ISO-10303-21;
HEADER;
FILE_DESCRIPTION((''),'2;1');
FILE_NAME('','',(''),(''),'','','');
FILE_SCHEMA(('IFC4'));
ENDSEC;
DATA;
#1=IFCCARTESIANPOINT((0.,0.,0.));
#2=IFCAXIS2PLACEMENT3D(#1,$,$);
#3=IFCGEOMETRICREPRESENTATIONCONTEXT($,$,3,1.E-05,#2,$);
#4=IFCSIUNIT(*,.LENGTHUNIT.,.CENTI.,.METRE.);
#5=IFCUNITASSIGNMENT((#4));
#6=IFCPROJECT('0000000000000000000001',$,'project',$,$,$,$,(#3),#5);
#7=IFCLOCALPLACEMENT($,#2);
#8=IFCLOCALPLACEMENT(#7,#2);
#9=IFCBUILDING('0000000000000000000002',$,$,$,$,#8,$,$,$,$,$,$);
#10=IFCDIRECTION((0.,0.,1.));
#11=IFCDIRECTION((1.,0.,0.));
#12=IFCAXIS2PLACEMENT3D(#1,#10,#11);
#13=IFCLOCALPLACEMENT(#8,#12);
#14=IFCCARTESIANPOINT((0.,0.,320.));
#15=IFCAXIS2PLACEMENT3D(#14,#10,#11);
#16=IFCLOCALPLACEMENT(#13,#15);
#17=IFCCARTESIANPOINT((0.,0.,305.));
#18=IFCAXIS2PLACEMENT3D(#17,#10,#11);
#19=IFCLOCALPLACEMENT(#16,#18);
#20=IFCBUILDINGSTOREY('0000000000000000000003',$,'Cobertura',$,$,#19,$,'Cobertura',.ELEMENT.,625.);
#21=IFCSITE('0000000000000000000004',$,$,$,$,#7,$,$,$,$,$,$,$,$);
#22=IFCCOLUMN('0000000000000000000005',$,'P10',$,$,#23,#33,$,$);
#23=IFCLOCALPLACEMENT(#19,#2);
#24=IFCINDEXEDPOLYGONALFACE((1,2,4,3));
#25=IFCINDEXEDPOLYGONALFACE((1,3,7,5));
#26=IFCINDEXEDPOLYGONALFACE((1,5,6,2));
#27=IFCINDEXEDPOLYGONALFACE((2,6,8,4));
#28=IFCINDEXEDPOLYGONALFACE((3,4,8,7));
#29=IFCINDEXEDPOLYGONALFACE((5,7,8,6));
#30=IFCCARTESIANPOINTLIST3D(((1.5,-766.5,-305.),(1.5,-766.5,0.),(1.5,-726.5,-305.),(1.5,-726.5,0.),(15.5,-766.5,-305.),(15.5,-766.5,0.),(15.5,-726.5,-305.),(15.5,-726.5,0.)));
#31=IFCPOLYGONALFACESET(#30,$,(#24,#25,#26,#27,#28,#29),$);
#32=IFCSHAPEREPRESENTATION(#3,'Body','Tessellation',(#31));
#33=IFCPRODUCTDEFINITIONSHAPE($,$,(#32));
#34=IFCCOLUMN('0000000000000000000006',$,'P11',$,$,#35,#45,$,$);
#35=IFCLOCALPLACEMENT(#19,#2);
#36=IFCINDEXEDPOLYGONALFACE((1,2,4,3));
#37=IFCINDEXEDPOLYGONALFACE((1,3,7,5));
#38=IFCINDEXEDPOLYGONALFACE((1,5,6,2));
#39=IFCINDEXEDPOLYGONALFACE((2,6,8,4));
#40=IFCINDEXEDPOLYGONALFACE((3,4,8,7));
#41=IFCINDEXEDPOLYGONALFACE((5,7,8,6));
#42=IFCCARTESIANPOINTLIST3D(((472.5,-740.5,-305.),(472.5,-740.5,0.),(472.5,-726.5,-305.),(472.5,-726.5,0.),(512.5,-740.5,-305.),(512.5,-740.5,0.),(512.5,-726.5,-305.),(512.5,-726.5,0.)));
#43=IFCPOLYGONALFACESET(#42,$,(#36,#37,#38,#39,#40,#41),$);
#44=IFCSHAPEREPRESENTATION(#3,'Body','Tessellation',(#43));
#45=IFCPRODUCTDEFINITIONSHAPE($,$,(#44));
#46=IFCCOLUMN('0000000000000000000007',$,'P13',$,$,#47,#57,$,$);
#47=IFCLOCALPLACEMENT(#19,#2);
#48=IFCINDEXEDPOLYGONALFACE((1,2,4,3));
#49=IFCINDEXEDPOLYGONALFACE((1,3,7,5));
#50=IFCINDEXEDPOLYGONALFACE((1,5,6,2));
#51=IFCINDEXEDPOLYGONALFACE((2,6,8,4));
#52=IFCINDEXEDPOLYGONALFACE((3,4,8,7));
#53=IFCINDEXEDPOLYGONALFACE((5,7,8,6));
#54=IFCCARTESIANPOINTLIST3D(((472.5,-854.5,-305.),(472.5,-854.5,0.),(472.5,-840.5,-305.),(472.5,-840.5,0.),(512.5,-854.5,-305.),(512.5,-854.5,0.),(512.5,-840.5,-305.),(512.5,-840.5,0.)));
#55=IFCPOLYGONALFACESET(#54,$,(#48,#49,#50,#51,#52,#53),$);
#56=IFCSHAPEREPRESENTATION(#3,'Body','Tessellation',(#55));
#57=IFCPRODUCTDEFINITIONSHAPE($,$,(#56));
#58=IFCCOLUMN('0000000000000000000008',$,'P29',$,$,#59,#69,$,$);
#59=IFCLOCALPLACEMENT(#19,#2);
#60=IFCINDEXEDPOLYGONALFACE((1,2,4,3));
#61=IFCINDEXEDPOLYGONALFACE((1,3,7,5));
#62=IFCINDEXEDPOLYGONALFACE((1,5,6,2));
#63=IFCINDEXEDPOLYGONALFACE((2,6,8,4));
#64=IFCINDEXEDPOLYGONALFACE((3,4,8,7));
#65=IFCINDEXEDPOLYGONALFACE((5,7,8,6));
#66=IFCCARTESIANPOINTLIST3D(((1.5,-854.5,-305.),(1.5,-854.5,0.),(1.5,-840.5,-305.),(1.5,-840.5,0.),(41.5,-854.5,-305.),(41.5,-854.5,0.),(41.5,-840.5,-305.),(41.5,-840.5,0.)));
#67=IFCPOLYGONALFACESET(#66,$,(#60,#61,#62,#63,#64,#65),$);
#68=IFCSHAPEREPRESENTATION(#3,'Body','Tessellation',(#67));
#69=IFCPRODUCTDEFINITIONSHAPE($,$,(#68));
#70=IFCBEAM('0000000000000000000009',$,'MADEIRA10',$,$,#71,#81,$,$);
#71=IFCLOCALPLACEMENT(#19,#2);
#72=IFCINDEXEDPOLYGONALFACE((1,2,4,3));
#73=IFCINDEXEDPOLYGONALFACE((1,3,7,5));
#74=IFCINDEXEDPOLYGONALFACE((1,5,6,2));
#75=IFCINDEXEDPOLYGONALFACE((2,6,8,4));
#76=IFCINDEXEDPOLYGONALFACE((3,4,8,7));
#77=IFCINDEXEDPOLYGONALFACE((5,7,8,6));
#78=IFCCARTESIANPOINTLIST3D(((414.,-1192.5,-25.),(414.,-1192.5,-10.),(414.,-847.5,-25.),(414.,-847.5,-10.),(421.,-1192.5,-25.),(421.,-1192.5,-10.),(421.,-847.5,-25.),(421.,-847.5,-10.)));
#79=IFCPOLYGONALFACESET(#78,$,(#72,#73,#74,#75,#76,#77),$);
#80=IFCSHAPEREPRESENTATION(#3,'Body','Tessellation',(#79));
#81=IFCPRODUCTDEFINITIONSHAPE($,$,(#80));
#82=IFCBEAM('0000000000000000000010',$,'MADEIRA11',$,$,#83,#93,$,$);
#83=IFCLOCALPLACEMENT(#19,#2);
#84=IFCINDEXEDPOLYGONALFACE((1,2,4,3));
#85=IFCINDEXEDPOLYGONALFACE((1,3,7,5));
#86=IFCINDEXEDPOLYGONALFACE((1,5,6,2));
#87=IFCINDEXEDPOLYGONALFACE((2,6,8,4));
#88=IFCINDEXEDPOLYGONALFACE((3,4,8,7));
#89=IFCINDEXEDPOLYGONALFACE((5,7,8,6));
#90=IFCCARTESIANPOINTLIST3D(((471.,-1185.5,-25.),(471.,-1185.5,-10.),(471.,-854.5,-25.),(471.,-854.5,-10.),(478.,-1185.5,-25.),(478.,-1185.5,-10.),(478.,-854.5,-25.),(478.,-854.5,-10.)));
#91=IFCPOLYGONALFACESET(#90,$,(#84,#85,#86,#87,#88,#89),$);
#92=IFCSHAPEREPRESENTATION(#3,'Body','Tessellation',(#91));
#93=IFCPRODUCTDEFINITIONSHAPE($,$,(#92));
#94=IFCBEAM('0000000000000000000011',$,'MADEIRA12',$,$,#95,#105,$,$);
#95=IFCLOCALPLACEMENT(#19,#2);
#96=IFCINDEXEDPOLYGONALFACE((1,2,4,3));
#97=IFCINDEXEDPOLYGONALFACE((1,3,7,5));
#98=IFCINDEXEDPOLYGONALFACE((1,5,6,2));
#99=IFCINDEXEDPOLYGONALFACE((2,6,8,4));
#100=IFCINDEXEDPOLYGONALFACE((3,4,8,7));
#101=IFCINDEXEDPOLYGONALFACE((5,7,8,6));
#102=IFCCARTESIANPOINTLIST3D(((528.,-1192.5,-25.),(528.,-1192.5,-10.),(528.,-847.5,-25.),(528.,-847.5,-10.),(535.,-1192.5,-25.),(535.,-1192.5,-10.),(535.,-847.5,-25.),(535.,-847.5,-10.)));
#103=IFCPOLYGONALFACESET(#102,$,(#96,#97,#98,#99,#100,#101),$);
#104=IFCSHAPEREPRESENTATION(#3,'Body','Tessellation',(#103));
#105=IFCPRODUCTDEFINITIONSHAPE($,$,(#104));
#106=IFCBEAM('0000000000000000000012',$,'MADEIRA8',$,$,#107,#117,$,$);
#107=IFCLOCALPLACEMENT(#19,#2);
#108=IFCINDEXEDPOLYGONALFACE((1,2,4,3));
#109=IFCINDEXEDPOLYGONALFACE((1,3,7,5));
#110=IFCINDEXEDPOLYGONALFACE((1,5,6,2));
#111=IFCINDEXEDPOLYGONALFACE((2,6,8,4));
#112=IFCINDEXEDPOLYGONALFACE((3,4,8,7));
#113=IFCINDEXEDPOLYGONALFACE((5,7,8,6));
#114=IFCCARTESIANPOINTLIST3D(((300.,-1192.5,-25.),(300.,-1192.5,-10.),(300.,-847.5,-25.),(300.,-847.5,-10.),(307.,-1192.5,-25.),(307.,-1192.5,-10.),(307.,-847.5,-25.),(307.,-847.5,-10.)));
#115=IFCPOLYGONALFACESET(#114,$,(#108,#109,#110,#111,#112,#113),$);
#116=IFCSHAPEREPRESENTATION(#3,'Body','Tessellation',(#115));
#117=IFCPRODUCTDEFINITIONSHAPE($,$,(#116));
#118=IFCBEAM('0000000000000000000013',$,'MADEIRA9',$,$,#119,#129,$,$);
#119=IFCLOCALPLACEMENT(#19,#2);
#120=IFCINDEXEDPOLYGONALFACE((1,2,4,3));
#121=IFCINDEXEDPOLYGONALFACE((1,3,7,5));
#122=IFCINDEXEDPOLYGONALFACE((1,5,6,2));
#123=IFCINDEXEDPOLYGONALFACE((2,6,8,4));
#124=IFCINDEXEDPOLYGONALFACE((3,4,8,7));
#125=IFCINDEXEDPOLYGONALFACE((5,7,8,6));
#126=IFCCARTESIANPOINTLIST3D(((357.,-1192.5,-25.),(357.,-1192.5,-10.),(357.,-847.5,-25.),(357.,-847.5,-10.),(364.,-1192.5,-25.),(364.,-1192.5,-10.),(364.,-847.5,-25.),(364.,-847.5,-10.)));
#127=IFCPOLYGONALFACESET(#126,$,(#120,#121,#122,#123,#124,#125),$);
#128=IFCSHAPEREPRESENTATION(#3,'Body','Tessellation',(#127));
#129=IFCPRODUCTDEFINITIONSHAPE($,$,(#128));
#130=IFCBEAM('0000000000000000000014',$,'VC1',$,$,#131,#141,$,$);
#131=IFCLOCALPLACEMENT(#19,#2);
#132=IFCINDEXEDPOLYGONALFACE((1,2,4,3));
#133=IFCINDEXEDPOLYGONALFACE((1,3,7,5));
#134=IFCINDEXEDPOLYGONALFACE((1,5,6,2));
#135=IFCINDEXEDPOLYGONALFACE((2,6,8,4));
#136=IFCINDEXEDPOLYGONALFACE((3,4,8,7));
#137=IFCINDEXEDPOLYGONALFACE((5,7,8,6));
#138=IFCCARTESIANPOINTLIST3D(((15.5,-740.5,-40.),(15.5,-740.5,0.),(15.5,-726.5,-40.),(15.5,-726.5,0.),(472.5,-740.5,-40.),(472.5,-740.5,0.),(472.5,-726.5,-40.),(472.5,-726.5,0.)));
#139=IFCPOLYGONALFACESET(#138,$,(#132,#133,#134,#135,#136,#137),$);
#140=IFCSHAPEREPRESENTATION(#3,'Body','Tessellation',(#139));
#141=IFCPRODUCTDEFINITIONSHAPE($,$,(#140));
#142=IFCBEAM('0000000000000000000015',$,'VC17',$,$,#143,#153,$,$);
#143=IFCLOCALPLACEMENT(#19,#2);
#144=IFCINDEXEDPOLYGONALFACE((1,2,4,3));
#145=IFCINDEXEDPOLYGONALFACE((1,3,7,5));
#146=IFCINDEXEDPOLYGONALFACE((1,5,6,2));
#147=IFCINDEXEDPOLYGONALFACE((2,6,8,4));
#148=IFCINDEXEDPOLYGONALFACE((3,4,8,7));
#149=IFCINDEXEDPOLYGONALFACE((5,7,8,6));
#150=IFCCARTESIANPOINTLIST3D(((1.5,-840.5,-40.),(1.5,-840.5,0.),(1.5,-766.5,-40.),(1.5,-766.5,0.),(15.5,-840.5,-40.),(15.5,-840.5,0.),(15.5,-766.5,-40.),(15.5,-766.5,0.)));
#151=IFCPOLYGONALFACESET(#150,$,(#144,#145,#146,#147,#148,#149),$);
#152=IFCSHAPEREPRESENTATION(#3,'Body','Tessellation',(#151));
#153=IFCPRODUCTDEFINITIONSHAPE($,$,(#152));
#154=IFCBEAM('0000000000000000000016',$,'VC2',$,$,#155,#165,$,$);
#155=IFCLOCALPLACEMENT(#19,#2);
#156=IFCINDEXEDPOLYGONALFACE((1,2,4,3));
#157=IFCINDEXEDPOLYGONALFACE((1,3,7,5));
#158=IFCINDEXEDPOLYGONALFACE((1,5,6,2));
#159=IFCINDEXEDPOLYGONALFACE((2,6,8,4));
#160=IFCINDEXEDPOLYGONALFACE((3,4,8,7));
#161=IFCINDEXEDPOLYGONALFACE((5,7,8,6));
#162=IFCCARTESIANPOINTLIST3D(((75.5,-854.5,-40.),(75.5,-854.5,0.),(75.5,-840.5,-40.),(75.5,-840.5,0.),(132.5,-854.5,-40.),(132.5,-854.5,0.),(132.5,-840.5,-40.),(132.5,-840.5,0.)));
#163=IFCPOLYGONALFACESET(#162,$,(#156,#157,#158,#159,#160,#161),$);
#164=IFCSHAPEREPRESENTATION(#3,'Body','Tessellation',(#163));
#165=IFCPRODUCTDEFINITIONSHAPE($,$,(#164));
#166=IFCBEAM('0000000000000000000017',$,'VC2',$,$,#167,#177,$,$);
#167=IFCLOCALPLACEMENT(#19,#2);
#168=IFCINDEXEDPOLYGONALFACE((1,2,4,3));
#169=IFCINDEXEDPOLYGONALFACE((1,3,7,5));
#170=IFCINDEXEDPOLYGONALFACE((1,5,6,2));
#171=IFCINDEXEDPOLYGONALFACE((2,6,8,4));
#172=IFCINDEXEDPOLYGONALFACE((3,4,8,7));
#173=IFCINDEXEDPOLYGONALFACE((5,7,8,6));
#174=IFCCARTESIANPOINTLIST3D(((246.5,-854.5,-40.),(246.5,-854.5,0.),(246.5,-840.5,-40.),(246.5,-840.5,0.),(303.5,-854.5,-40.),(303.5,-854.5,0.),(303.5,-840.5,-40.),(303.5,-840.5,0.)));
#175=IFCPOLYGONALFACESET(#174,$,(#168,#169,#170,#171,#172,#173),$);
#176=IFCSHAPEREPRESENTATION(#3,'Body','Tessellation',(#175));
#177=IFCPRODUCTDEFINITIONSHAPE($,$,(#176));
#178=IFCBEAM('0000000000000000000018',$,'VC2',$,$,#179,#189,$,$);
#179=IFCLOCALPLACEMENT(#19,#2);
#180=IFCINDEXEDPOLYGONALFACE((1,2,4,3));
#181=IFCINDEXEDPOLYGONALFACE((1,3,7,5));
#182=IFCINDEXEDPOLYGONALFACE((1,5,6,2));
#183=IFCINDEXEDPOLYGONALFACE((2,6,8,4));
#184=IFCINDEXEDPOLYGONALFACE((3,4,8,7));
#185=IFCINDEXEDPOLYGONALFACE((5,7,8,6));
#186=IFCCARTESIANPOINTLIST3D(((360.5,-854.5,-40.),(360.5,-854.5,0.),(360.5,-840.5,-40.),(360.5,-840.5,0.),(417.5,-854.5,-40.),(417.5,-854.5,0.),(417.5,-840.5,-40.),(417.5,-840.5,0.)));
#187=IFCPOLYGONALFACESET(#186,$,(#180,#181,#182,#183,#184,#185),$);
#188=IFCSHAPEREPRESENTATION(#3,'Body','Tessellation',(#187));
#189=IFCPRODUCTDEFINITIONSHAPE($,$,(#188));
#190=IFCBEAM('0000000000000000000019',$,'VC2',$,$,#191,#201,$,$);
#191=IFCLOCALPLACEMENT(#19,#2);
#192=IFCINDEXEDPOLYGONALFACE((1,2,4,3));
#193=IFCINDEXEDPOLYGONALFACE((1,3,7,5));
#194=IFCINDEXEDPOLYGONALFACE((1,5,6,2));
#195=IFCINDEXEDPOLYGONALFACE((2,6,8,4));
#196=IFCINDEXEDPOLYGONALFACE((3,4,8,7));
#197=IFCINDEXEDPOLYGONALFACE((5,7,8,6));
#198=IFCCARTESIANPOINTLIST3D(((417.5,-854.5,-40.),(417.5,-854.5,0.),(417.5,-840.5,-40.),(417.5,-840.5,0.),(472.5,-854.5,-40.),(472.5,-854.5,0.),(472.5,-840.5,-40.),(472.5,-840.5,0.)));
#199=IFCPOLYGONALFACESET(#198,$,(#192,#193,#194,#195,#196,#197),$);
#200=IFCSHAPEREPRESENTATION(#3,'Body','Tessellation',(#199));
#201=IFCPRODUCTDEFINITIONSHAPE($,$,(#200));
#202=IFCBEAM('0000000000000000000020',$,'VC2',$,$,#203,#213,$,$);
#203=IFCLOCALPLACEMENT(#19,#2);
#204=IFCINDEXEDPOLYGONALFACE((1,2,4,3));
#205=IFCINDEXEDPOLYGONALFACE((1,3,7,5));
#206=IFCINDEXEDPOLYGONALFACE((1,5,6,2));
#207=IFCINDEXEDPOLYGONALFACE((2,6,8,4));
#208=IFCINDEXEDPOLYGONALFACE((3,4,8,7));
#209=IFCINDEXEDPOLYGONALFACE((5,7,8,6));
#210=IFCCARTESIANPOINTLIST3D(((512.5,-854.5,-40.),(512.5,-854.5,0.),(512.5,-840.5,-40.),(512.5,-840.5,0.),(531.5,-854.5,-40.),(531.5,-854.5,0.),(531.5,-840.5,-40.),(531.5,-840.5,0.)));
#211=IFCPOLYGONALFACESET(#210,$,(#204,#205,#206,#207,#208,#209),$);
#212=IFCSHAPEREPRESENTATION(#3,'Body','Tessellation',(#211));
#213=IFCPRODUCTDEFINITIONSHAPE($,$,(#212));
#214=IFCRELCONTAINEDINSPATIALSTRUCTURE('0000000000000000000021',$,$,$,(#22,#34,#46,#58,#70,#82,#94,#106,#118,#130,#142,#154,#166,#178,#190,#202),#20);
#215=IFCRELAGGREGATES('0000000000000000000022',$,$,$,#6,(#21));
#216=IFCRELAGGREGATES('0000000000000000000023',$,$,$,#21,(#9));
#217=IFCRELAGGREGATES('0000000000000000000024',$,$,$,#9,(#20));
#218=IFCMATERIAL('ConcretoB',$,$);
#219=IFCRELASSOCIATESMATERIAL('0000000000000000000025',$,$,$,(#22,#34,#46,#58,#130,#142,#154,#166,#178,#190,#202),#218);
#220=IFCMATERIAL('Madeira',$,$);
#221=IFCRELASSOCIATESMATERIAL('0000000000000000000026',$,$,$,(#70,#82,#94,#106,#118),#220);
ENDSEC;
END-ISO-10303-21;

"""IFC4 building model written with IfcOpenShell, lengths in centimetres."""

from ifc_helpers import new_model, si_unit, frame, origin, origin_with_axes, place, context, project, spatial, polyline, outline, extrude, material, element, save


model = new_model("IFC4")

# Units and contexts
context_of_model = context(None, 3, precision=1e-05, world=origin())
ifc_project = project(units=[si_unit("LENGTHUNIT", "METRE", prefix="CENTI")], contexts=[context_of_model])

# Site, building, storey
site_placement = place(None, origin())
site = spatial("IfcSite", under=ifc_project, at=site_placement)
building_placement = place(site_placement, origin())
building = spatial("IfcBuilding", under=site, at=building_placement)
placement_1 = place(building_placement, origin_with_axes())
placement_2 = place(placement_1, frame((0.0, 0.0, 320.0), z_axis=(0.0, 0.0, 1.0), x_axis=(1.0, 0.0, 0.0)))
storey_placement = place(placement_2, frame((0.0, 0.0, 305.0), z_axis=(0.0, 0.0, 1.0), x_axis=(1.0, 0.0, 0.0)))
storey = spatial("IfcBuildingStorey", under=building, at=storey_placement, Name="Cobertura", LongName="Cobertura", CompositionType="ELEMENT", Elevation=625.0)

# Columns
ifc_material_1 = material(Name="ConcretoB")
column_1_placement = place(storey_placement, frame((8.5, -746.5, 0.0), z_axis=(0.0, 0.0, 1.0), x_axis=(1.0, 0.0, 0.0)))
element("IfcColumn", 1, at=column_1_placement, inside=storey, material=ifc_material_1, Name="P10", context=context_of_model, shape_type="SolidModel", body=[
    extrude(outline(polyline([(7.0, 20.0), (-7.0, 20.0), (-7.0, -20.0), (7.0, -20.0), (7.0, 20.0)])), frame((0.0, 0.0, 0.0), z_axis=(0.0, 0.0, 1.0), x_axis=(1.0, 0.0, 0.0)), (0.0, 0.0, -1.0), 305.0),
])
for number, where, z_axis, x_axis, name in (
    (2, (492.5, -733.5, 0.0), (0.0, 0.0, 1.0), (1.0, 0.0, 0.0), "P11"),
    (3, (492.5, -847.5, 0.0), (0.0, 0.0, 1.0), (1.0, 0.0, 0.0), "P13"),
):
    element("IfcColumn", number, at=place(storey_placement, frame(where, z_axis=z_axis, x_axis=x_axis)), inside=storey, material=ifc_material_1, Name=name, context=context_of_model, shape_type="SolidModel", body=[
        extrude(outline(polyline([(-20.0, 7.0), (-20.0, -7.0), (20.0, -7.0), (20.0, 7.0), (-20.0, 7.0)])), origin_with_axes(), (0.0, 0.0, -1.0), 305.0),
    ])
column_2_placement = place(storey_placement, frame((21.5, -847.5, 0.0), z_axis=(0.0, 0.0, 1.0), x_axis=(1.0, 0.0, 0.0)))
element("IfcColumn", 4, at=column_2_placement, inside=storey, material=ifc_material_1, Name="P29", context=context_of_model, shape_type="SolidModel", body=[
    extrude(outline(polyline([(20.0, -7.0), (20.0, 7.0), (-20.0, 7.0), (-20.0, -7.0), (20.0, -7.0)])), origin_with_axes(), (0.0, 0.0, -1.0), 305.0),
])

# Beams
ifc_material_2 = material(Name="Madeira")
beam_1_placement = place(storey_placement, frame((417.5, -1020.0, -10.0), z_axis=(0.0, 0.0, 1.0), x_axis=(1.0, 0.0, 0.0)))
element("IfcBeam", 5, at=beam_1_placement, inside=storey, material=ifc_material_2, Name="MADEIRA10", context=context_of_model, shape_type="SolidModel", body=[
    extrude(outline(polyline([(-3.5, -7.5), (-3.5, 7.5), (3.5, 7.5), (3.5, -7.5), (-3.5, -7.5)])), frame((0.0, -172.5, -7.5), z_axis=(0.0, 1.0, 0.0), x_axis=(1.0, 0.0, 0.0)), (0.0, 0.0, 1.0), 345.0),
])
beam_2_placement = place(storey_placement, frame((474.5, -1020.0, -10.0), z_axis=(0.0, 0.0, 1.0), x_axis=(1.0, 0.0, 0.0)))
element("IfcBeam", 6, at=beam_2_placement, inside=storey, material=ifc_material_2, Name="MADEIRA11", context=context_of_model, shape_type="SolidModel", body=[
    extrude(outline(polyline([(-3.5, -7.5), (-3.5, 7.5), (3.5, 7.5), (3.5, -7.5), (-3.5, -7.5)])), frame((0.0, -165.5, -7.5), z_axis=(0.0, 1.0, 0.0), x_axis=(1.0, 0.0, 0.0)), (0.0, 0.0, 1.0), 331.0),
])
for number, where, z_axis, x_axis, name in (
    (7, (531.5, -1020.0, -10.0), (0.0, 0.0, 1.0), (1.0, 0.0, 0.0), "MADEIRA12"),
    (8, (303.5, -1020.0, -10.0), (0.0, 0.0, 1.0), (1.0, 0.0, 0.0), "MADEIRA8"),
    (9, (360.5, -1020.0, -10.0), (0.0, 0.0, 1.0), (1.0, 0.0, 0.0), "MADEIRA9"),
):
    element("IfcBeam", number, at=place(storey_placement, frame(where, z_axis=z_axis, x_axis=x_axis)), inside=storey, material=ifc_material_2, Name=name, context=context_of_model, shape_type="SolidModel", body=[
        extrude(outline(polyline([(-3.5, -7.5), (-3.5, 7.5), (3.5, 7.5), (3.5, -7.5), (-3.5, -7.5)])), frame((0.0, -172.5, -7.5), z_axis=(0.0, 1.0, 0.0), x_axis=(1.0, 0.0, 0.0)), (0.0, 0.0, 1.0), 345.0),
    ])
beam_3_placement = place(storey_placement, frame((244.0, -733.5, 0.0), z_axis=(0.0, 0.0, 1.0), x_axis=(1.0, 0.0, 0.0)))
element("IfcBeam", 10, at=beam_3_placement, inside=storey, material=ifc_material_1, Name="VC1", context=context_of_model, shape_type="SolidModel", body=[
    extrude(outline(polyline([(-7.0, -20.0), (7.0, -20.0), (7.0, 20.0), (-7.0, 20.0), (-7.0, -20.0)])), frame((-228.5, 0.0, -20.0), z_axis=(1.0, 0.0, 0.0), x_axis=(0.0, -1.0, 0.0)), (0.0, 0.0, 1.0), 457.0),
])
beam_4_placement = place(storey_placement, frame((8.5, -803.5, 0.0), z_axis=(0.0, 0.0, 1.0), x_axis=(1.0, 0.0, 0.0)))
element("IfcBeam", 11, at=beam_4_placement, inside=storey, material=ifc_material_1, Name="VC17", context=context_of_model, shape_type="SolidModel", body=[
    extrude(outline(polyline([(-7.0, -20.0), (7.0, -20.0), (7.0, 20.0), (-7.0, 20.0), (-7.0, -20.0)])), frame((0.0, -37.0, -20.0), z_axis=(0.0, 1.0, 0.0), x_axis=(1.0, 0.0, 0.0)), (0.0, 0.0, 1.0), 74.0),
])
for number, where, z_axis, x_axis, name in (
    (12, (104.0, -847.5, 0.0), (0.0, 0.0, 1.0), (1.0, 0.0, 0.0), "VC2"),
    (13, (275.0, -847.5, 0.0), (0.0, 0.0, 1.0), (1.0, 0.0, 0.0), "VC2"),
    (14, (389.0, -847.5, 0.0), (0.0, 0.0, 1.0), (1.0, 0.0, 0.0), "VC2"),
):
    element("IfcBeam", number, at=place(storey_placement, frame(where, z_axis=z_axis, x_axis=x_axis)), inside=storey, material=ifc_material_1, Name=name, context=context_of_model, shape_type="SolidModel", body=[
        extrude(outline(polyline([(-7.0, -20.0), (7.0, -20.0), (7.0, 20.0), (-7.0, 20.0), (-7.0, -20.0)])), frame((-28.5, 0.0, -20.0), z_axis=(1.0, 0.0, 0.0), x_axis=(0.0, -1.0, 0.0)), (0.0, 0.0, 1.0), 57.0),
    ])
beam_5_placement = place(storey_placement, frame((445.0, -847.5, 0.0), z_axis=(0.0, 0.0, 1.0), x_axis=(1.0, 0.0, 0.0)))
element("IfcBeam", 15, at=beam_5_placement, inside=storey, material=ifc_material_1, Name="VC2", context=context_of_model, shape_type="SolidModel", body=[
    extrude(outline(polyline([(-7.0, -20.0), (7.0, -20.0), (7.0, 20.0), (-7.0, 20.0), (-7.0, -20.0)])), frame((-27.5, 0.0, -20.0), z_axis=(1.0, 0.0, 0.0), x_axis=(0.0, -1.0, 0.0)), (0.0, 0.0, 1.0), 55.0),
])
beam_6_placement = place(storey_placement, frame((522.0, -847.5, 0.0), z_axis=(0.0, 0.0, 1.0), x_axis=(1.0, 0.0, 0.0)))
element("IfcBeam", 16, at=beam_6_placement, inside=storey, material=ifc_material_1, Name="VC2", context=context_of_model, shape_type="SolidModel", body=[
    extrude(outline(polyline([(-7.0, -20.0), (7.0, -20.0), (7.0, 20.0), (-7.0, 20.0), (-7.0, -20.0)])), frame((-9.5, 0.0, -20.0), z_axis=(1.0, 0.0, 0.0), x_axis=(0.0, -1.0, 0.0)), (0.0, 0.0, 1.0), 19.0),
])

save(model, "model.ifc")
